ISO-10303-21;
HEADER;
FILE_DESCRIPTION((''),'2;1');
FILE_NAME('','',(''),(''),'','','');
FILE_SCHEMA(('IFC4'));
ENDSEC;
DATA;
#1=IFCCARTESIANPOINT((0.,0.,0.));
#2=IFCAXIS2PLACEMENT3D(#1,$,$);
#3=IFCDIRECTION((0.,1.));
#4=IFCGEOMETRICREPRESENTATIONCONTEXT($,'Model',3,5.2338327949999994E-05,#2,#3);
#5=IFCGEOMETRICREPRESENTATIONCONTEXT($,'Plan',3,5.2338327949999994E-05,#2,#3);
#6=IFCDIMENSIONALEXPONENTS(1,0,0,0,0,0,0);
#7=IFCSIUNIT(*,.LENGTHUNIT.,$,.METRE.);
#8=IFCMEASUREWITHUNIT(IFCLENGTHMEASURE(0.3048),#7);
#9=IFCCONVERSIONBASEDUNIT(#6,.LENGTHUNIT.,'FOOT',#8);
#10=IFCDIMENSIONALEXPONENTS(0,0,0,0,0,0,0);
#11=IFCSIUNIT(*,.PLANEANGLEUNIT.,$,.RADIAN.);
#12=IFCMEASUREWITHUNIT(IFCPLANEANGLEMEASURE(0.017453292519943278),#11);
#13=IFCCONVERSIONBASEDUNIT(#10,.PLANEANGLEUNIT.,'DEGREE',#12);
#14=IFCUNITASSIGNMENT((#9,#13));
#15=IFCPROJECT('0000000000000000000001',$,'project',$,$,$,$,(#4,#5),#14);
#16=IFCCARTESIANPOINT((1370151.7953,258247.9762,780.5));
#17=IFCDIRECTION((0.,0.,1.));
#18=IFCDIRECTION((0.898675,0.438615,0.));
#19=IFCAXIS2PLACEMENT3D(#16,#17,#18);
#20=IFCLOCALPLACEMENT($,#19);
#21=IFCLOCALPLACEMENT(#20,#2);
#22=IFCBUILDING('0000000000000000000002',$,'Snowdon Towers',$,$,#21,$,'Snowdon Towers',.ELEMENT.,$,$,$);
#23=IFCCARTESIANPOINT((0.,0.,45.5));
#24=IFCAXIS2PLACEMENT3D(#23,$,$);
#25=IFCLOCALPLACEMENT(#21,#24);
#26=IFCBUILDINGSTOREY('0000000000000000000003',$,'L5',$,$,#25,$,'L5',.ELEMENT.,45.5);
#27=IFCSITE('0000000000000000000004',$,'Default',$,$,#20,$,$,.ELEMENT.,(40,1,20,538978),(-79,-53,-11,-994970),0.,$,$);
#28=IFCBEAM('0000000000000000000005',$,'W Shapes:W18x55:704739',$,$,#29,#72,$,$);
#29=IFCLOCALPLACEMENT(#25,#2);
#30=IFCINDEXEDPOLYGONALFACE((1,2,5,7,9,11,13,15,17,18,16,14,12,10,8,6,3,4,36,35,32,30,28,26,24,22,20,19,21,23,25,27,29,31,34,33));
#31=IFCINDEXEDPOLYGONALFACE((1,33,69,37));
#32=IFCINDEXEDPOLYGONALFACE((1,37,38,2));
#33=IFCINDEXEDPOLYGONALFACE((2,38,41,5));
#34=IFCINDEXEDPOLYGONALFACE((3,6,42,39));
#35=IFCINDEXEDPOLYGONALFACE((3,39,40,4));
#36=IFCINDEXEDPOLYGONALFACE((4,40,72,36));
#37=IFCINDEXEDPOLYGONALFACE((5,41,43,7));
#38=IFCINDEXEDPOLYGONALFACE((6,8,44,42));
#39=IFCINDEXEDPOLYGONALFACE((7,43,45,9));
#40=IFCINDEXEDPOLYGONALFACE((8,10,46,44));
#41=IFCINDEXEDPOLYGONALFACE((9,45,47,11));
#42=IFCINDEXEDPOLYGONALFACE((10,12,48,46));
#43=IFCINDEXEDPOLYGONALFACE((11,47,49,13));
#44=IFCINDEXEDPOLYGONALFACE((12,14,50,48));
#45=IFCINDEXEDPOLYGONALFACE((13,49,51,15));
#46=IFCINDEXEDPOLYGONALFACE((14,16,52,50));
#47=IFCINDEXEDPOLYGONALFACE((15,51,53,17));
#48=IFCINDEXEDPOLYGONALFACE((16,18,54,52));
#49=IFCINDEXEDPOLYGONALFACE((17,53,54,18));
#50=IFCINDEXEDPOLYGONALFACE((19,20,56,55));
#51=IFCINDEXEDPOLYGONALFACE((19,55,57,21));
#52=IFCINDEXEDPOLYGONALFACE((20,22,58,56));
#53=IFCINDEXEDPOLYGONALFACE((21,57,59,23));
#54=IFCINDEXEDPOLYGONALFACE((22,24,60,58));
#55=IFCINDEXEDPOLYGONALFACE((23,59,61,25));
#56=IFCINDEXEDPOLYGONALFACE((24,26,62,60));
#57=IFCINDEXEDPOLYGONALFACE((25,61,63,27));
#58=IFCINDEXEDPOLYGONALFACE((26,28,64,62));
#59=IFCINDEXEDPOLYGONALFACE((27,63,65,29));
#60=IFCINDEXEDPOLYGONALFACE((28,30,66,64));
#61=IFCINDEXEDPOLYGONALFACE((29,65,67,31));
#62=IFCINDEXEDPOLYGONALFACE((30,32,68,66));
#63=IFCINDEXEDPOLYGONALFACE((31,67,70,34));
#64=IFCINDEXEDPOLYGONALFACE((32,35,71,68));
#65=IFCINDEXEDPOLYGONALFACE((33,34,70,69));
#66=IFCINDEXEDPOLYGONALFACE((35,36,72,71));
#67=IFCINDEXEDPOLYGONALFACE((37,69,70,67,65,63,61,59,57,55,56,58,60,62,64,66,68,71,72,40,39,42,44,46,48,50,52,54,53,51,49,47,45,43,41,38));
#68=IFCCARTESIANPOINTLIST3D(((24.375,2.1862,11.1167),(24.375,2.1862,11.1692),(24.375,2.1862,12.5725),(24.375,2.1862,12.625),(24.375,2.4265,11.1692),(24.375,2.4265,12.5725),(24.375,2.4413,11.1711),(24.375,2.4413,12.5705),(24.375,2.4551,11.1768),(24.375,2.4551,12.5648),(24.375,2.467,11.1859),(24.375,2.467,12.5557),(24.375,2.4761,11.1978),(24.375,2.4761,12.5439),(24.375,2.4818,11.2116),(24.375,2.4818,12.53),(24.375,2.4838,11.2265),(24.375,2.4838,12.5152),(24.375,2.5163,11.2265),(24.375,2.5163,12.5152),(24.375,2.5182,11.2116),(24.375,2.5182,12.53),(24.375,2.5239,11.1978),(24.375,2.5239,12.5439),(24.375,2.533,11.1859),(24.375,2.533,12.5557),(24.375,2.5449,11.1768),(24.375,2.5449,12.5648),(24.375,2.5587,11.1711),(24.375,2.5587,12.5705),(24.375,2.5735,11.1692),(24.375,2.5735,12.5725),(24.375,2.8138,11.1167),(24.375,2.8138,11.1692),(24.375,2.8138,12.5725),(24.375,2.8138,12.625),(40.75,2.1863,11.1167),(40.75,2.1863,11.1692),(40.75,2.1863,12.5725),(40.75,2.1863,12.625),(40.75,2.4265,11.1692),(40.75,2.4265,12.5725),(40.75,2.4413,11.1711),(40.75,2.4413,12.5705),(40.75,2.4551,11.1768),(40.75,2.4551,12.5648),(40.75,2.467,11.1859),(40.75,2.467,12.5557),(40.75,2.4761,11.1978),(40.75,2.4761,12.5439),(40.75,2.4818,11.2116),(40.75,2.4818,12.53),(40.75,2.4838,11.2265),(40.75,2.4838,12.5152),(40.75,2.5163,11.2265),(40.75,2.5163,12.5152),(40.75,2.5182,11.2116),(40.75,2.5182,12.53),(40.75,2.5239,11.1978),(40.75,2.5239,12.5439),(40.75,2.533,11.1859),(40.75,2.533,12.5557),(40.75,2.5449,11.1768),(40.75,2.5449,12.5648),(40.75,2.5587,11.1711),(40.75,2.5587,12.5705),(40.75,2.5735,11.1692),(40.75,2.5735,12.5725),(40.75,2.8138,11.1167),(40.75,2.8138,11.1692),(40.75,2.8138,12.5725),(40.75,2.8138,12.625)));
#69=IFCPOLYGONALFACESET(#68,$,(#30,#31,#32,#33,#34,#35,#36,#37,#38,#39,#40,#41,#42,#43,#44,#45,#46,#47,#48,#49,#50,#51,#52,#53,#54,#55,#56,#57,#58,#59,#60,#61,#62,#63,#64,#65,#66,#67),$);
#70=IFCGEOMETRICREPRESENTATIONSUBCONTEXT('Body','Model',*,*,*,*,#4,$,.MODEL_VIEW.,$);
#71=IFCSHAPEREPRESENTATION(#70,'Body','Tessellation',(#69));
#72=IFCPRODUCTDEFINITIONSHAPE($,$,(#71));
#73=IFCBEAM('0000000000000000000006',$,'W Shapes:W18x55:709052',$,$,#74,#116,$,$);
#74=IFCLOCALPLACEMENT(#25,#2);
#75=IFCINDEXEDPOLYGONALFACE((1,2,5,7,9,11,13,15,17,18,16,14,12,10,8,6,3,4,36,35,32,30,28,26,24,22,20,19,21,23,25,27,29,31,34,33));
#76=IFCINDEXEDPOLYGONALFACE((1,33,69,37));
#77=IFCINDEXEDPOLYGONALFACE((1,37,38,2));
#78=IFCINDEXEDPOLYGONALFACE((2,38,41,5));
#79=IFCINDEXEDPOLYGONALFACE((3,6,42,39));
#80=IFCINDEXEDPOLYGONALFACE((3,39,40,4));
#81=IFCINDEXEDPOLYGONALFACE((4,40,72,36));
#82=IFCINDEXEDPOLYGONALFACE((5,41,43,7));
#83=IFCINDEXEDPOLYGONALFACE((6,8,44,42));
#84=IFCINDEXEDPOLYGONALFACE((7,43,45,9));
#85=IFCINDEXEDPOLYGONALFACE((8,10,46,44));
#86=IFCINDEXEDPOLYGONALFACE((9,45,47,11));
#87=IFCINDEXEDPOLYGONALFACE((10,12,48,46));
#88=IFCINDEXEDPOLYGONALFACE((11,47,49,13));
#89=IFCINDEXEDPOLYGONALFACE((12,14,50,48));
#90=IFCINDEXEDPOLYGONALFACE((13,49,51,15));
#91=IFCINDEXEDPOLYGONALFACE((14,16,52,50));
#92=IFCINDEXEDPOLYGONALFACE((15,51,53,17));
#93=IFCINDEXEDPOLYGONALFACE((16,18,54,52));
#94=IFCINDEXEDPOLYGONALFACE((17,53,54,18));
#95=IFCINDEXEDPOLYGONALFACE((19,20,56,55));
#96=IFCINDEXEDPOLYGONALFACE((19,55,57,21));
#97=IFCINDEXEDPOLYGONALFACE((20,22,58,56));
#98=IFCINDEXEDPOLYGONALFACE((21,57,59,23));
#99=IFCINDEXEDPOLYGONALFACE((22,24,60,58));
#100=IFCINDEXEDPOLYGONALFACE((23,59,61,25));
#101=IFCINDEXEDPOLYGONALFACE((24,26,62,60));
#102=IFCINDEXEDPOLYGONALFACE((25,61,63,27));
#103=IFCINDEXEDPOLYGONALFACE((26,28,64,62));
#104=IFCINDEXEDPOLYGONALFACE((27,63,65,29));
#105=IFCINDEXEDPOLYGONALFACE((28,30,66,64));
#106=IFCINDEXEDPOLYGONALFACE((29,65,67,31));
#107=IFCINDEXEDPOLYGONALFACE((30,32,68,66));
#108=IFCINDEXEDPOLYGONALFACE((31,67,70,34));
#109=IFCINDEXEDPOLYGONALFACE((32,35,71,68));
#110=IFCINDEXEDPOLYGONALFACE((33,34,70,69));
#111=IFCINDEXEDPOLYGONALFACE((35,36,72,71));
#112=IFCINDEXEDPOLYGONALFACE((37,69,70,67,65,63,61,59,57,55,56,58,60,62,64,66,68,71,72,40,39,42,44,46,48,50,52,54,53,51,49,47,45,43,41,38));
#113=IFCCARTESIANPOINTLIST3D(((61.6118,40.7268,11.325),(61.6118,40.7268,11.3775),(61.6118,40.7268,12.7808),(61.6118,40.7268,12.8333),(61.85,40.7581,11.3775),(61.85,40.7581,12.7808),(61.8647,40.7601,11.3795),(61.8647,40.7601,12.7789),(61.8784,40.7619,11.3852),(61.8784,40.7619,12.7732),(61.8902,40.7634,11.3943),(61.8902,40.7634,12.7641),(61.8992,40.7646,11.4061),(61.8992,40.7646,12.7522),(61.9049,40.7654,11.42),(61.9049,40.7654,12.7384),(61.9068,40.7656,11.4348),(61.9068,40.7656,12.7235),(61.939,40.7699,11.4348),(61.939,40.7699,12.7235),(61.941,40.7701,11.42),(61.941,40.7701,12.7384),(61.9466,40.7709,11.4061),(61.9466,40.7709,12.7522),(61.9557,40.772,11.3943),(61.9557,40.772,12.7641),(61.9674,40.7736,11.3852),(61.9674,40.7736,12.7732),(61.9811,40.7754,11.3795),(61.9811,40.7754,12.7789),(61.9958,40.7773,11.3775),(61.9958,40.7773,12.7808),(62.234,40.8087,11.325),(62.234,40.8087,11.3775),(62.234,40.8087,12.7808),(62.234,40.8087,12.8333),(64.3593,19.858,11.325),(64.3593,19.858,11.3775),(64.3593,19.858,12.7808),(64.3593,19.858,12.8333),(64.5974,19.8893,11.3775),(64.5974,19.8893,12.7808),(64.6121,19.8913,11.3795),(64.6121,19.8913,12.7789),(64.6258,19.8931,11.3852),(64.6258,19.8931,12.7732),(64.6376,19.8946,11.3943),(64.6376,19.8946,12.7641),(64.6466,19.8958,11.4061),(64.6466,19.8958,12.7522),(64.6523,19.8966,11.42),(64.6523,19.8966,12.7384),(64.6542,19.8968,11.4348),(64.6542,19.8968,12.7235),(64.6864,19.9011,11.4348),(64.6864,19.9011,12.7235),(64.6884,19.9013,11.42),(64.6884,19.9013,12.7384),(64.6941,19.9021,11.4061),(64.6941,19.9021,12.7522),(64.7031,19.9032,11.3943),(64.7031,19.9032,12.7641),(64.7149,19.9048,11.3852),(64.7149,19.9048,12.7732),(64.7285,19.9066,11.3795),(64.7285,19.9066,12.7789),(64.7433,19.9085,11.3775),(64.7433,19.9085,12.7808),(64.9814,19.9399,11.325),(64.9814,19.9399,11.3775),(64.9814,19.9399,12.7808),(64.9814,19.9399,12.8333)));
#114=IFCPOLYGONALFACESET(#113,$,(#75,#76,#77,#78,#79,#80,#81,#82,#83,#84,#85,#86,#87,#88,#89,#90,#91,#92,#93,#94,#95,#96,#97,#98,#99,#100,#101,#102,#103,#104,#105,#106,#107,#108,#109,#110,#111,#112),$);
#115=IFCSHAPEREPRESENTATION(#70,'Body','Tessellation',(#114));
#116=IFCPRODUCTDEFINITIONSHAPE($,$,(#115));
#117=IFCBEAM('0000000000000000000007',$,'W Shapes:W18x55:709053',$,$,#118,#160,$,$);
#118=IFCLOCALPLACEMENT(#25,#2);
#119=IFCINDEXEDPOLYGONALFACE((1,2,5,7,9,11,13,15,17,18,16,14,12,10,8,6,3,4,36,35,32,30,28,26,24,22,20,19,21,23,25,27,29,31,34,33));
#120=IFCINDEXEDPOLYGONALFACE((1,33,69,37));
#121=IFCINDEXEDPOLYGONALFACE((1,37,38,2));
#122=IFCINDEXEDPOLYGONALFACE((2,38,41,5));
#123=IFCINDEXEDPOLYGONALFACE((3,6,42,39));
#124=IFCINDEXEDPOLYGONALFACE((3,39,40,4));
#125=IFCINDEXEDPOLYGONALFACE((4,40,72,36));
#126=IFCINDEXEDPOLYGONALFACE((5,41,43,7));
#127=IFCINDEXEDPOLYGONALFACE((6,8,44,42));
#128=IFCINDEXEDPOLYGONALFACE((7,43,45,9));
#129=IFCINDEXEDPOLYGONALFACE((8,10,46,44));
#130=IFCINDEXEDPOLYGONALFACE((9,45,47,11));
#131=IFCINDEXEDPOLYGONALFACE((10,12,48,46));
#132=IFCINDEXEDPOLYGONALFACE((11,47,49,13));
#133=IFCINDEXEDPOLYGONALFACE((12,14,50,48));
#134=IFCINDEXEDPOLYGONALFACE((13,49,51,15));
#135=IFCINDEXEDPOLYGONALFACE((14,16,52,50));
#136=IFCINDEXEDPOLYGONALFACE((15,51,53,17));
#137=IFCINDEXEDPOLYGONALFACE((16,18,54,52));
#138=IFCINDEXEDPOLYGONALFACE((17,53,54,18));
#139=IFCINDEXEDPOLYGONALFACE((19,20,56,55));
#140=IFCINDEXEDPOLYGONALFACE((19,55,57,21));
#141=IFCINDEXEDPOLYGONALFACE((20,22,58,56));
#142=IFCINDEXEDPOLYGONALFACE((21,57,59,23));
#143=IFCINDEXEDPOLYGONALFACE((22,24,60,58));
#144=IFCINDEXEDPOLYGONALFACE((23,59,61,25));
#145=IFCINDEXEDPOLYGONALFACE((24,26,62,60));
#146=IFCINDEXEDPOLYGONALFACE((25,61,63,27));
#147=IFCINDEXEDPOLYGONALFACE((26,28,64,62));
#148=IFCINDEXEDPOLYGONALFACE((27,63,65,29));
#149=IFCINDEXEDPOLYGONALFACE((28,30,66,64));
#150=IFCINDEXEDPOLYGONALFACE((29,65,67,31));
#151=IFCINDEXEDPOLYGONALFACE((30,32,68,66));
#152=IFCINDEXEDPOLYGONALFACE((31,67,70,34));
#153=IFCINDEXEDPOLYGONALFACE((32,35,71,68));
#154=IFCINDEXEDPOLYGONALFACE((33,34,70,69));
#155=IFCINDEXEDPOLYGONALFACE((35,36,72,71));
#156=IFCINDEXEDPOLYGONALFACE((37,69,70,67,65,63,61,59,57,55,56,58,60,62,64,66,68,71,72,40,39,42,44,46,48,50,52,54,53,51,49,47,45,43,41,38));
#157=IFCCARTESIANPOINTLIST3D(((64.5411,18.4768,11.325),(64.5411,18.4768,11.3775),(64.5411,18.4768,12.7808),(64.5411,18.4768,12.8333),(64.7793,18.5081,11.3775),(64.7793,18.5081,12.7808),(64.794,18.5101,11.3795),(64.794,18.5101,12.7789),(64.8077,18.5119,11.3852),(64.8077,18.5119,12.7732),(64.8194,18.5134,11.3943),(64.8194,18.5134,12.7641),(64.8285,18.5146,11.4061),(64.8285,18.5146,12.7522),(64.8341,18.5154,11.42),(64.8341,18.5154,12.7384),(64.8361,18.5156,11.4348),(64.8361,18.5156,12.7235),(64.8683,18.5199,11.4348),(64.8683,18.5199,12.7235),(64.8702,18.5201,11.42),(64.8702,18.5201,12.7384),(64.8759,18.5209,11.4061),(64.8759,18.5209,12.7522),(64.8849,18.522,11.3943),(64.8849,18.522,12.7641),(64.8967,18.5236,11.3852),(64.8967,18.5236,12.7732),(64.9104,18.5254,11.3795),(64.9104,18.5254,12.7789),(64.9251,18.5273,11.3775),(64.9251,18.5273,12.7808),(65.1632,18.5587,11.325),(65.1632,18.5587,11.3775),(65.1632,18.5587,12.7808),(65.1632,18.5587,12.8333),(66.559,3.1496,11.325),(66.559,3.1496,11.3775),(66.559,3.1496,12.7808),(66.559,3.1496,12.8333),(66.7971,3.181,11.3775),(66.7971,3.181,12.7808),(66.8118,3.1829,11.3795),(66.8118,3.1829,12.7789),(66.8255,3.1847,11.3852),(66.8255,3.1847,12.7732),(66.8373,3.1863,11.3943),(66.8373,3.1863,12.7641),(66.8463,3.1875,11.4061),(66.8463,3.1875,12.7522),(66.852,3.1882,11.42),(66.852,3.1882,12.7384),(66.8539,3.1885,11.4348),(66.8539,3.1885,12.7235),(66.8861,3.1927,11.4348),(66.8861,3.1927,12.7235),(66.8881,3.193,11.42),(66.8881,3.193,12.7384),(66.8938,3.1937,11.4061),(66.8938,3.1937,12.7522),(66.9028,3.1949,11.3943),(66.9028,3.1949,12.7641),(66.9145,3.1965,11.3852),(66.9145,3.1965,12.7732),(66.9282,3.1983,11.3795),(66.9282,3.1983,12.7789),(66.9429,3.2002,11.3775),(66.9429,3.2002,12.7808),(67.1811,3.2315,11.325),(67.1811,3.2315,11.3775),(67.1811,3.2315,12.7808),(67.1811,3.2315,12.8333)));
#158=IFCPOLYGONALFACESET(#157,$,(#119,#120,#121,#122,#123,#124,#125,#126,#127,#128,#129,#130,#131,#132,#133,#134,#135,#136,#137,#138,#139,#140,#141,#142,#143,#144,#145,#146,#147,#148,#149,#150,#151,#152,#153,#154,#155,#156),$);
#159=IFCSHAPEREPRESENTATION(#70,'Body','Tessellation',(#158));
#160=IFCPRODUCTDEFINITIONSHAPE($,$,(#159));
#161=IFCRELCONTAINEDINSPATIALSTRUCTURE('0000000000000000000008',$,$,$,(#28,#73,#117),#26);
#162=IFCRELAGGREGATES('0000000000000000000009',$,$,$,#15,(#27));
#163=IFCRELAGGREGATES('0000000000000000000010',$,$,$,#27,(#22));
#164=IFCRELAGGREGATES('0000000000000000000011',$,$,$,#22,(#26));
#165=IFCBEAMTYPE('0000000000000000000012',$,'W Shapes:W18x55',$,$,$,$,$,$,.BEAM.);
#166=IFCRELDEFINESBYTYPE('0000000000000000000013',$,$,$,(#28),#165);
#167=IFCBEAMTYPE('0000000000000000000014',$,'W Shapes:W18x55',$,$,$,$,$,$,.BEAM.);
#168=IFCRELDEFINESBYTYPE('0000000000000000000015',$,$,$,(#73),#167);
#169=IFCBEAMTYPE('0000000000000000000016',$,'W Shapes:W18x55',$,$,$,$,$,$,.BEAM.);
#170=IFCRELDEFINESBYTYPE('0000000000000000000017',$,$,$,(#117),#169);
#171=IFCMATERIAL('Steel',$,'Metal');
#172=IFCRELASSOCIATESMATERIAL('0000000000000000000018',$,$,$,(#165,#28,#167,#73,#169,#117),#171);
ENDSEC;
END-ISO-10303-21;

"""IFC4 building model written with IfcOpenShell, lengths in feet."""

from ifc_helpers import new_model, entity, si_unit, converted_unit, direction, frame, origin, place, context, subcontext, project, spatial, line, arc, indexed_curve, outline, extrude, source, transform, mapped, material, type_object, type_shapes, element, save


model = new_model("IFC4")

# Units and contexts
model_context = context("Model", 3, precision=5.2338327949999994e-05, world=origin(), true_north=direction((0.0, 1.0)))
plan_context = context("Plan", 3, precision=5.2338327949999994e-05, world=origin(), true_north=direction((0.0, 1.0)))
body_context = subcontext(model_context, "Body", "Model", "MODEL_VIEW")
ifc_project = project(units=[converted_unit("LENGTHUNIT", "FOOT", entity("IfcLengthMeasure", 0.3048), si_unit("LENGTHUNIT", "METRE"), dimensions=[1, 0, 0, 0, 0, 0, 0]), converted_unit("PLANEANGLEUNIT", "DEGREE", entity("IfcPlaneAngleMeasure", 0.017453292519943278), si_unit("PLANEANGLEUNIT", "RADIAN"), dimensions=[0, 0, 0, 0, 0, 0, 0])], contexts=[model_context, plan_context])

# Site, building, storey
site_placement = place(None, frame((1370151.7953, 258247.9762, 780.5), z_axis=(0.0, 0.0, 1.0), x_axis=(0.898675, 0.438615, 0.0)))
site = spatial("IfcSite", under=ifc_project, at=site_placement, Name="Default", CompositionType="ELEMENT", RefLatitude=(40, 1, 20, 538978), RefLongitude=(-79, -53, -11, -994970), RefElevation=0.0)
building_placement = place(site_placement, origin())
building = spatial("IfcBuilding", under=site, at=building_placement, Name="Snowdon Towers", LongName="Snowdon Towers", CompositionType="ELEMENT")
storey_placement = place(building_placement, frame((0.0, 0.0, 45.5)))
storey = spatial("IfcBuildingStorey", under=building, at=storey_placement, Name="L5", LongName="L5", CompositionType="ELEMENT", Elevation=45.5)

# Shared definitions
ifc_material = material(Name="Steel", Category="Metal")

# Beams
beam_type_1 = type_object("IfcBeamType", Name="W Shapes:W18x55", PredefinedType="BEAM", material=ifc_material)
shared_shape_1 = source(origin(), body_context, "Body", "SweptSolid", [
    extrude(outline(indexed_curve([(-0.7542, -0.3138), (-0.7017, -0.3138), (-0.7017, -0.0735), (-0.6849, -0.033), (-0.6444, -0.0162), (0.6444, -0.0162), (0.6849, -0.033), (0.7017, -0.0735), (0.7017, -0.3138), (0.7542, -0.3138), (0.7542, 0.3138), (0.7017, 0.3138), (0.7017, 0.0735), (0.6849, 0.033), (0.6444, 0.0163), (-0.6444, 0.0163), (-0.6849, 0.033), (-0.7017, 0.0735), (-0.7017, 0.3137), (-0.7542, 0.3137)], segments=[line(1, 2, 3), arc(3, 4, 5), line(5, 6), arc(6, 7, 8), line(8, 9, 10, 11, 12, 13), arc(13, 14, 15), line(15, 16), arc(16, 17, 18), line(18, 19, 20, 1)], self_intersect=False)), frame((-7.9583, 0.0, 0.0), z_axis=(1.0, 0.0, 0.0), x_axis=(0.0, 0.0, -1.0)), (0.0, 0.0, 1.0), 16.375),
])
type_shapes(beam_type_1, [shared_shape_1])
beam_1_placement = place(storey_placement, frame((32.3333, 2.5, 11.8708)))
element("IfcBeam", 1, at=beam_1_placement, inside=storey, type_object=beam_type_1, material=ifc_material, Name="W Shapes:W18x55:704739", context=body_context, shape_type="MappedRepresentation", body=[
    mapped(shared_shape_1, transform((0.0, 0.0, 0.0), scale=1.0)),
])
beam_type_2 = type_object("IfcBeamType", Name="W Shapes:W18x55", PredefinedType="BEAM", material=ifc_material)
shared_shape_2 = source(origin(), body_context, "Body", "SweptSolid", [
    extrude(outline(indexed_curve([(-0.7542, -0.3138), (-0.7017, -0.3138), (-0.7017, -0.0735), (-0.6849, -0.033), (-0.6444, -0.0162), (0.6444, -0.0162), (0.6849, -0.033), (0.7017, -0.0735), (0.7017, -0.3138), (0.7542, -0.3138), (0.7542, 0.3138), (0.7017, 0.3138), (0.7017, 0.0735), (0.6849, 0.033), (0.6444, 0.0163), (-0.6444, 0.0163), (-0.6849, 0.033), (-0.7017, 0.0735), (-0.7017, 0.3137), (-0.7542, 0.3137)], segments=[line(1, 2, 3), arc(3, 4, 5), line(5, 6), arc(6, 7, 8), line(8, 9, 10, 11, 12, 13), arc(13, 14, 15), line(15, 16), arc(16, 17, 18), line(18, 19, 20, 1)], self_intersect=False)), frame((-10.5172, 0.0, 0.0), z_axis=(1.0, 0.0, 0.0), x_axis=(0.0, 0.0, -1.0)), (0.0, 0.0, 1.0), 21.0489),
])
type_shapes(beam_type_2, [shared_shape_2])
beam_2_placement = place(storey_placement, frame((63.2957, 30.3405, 12.0792), z_axis=(0.0, 0.0, 1.0), x_axis=(0.130526, -0.991445, 0.0)))
element("IfcBeam", 2, at=beam_2_placement, inside=storey, type_object=beam_type_2, material=ifc_material, Name="W Shapes:W18x55:709052", context=body_context, shape_type="MappedRepresentation", body=[
    mapped(shared_shape_2, transform((0.0, 0.0, 0.0), scale=1.0)),
])
beam_type_3 = type_object("IfcBeamType", Name="W Shapes:W18x55", PredefinedType="BEAM", material=ifc_material)
shared_shape_3 = source(origin(), body_context, "Body", "SweptSolid", [
    extrude(outline(indexed_curve([(-0.7542, -0.3138), (-0.7017, -0.3138), (-0.7017, -0.0735), (-0.6849, -0.033), (-0.6444, -0.0162), (0.6444, -0.0162), (0.6849, -0.033), (0.7017, -0.0735), (0.7017, -0.3138), (0.7542, -0.3138), (0.7542, 0.3138), (0.7017, 0.3138), (0.7017, 0.0735), (0.6849, 0.033), (0.6444, 0.0163), (-0.6444, 0.0163), (-0.6849, 0.033), (-0.7017, 0.0735), (-0.7017, 0.3137), (-0.7542, 0.3137)], segments=[line(1, 2, 3), arc(3, 4, 5), line(5, 6), arc(6, 7, 8), line(8, 9, 10, 11, 12, 13), arc(13, 14, 15), line(15, 16), arc(16, 17, 18), line(18, 19, 20, 1)], self_intersect=False)), frame((-7.8065, 0.0, 0.0), z_axis=(1.0, 0.0, 0.0), x_axis=(0.0, 0.0, -1.0)), (0.0, 0.0, 1.0), 15.4594),
])
type_shapes(beam_type_3, [shared_shape_3])
beam_3_placement = place(storey_placement, frame((65.8711, 10.778, 12.0792), z_axis=(0.0, 0.0, 1.0), x_axis=(0.130526, -0.991445, 0.0)))
element("IfcBeam", 3, at=beam_3_placement, inside=storey, type_object=beam_type_3, material=ifc_material, Name="W Shapes:W18x55:709053", context=body_context, shape_type="MappedRepresentation", body=[
    mapped(shared_shape_3, transform((0.0, 0.0, 0.0), scale=1.0)),
])

save(model, "model.ifc")
